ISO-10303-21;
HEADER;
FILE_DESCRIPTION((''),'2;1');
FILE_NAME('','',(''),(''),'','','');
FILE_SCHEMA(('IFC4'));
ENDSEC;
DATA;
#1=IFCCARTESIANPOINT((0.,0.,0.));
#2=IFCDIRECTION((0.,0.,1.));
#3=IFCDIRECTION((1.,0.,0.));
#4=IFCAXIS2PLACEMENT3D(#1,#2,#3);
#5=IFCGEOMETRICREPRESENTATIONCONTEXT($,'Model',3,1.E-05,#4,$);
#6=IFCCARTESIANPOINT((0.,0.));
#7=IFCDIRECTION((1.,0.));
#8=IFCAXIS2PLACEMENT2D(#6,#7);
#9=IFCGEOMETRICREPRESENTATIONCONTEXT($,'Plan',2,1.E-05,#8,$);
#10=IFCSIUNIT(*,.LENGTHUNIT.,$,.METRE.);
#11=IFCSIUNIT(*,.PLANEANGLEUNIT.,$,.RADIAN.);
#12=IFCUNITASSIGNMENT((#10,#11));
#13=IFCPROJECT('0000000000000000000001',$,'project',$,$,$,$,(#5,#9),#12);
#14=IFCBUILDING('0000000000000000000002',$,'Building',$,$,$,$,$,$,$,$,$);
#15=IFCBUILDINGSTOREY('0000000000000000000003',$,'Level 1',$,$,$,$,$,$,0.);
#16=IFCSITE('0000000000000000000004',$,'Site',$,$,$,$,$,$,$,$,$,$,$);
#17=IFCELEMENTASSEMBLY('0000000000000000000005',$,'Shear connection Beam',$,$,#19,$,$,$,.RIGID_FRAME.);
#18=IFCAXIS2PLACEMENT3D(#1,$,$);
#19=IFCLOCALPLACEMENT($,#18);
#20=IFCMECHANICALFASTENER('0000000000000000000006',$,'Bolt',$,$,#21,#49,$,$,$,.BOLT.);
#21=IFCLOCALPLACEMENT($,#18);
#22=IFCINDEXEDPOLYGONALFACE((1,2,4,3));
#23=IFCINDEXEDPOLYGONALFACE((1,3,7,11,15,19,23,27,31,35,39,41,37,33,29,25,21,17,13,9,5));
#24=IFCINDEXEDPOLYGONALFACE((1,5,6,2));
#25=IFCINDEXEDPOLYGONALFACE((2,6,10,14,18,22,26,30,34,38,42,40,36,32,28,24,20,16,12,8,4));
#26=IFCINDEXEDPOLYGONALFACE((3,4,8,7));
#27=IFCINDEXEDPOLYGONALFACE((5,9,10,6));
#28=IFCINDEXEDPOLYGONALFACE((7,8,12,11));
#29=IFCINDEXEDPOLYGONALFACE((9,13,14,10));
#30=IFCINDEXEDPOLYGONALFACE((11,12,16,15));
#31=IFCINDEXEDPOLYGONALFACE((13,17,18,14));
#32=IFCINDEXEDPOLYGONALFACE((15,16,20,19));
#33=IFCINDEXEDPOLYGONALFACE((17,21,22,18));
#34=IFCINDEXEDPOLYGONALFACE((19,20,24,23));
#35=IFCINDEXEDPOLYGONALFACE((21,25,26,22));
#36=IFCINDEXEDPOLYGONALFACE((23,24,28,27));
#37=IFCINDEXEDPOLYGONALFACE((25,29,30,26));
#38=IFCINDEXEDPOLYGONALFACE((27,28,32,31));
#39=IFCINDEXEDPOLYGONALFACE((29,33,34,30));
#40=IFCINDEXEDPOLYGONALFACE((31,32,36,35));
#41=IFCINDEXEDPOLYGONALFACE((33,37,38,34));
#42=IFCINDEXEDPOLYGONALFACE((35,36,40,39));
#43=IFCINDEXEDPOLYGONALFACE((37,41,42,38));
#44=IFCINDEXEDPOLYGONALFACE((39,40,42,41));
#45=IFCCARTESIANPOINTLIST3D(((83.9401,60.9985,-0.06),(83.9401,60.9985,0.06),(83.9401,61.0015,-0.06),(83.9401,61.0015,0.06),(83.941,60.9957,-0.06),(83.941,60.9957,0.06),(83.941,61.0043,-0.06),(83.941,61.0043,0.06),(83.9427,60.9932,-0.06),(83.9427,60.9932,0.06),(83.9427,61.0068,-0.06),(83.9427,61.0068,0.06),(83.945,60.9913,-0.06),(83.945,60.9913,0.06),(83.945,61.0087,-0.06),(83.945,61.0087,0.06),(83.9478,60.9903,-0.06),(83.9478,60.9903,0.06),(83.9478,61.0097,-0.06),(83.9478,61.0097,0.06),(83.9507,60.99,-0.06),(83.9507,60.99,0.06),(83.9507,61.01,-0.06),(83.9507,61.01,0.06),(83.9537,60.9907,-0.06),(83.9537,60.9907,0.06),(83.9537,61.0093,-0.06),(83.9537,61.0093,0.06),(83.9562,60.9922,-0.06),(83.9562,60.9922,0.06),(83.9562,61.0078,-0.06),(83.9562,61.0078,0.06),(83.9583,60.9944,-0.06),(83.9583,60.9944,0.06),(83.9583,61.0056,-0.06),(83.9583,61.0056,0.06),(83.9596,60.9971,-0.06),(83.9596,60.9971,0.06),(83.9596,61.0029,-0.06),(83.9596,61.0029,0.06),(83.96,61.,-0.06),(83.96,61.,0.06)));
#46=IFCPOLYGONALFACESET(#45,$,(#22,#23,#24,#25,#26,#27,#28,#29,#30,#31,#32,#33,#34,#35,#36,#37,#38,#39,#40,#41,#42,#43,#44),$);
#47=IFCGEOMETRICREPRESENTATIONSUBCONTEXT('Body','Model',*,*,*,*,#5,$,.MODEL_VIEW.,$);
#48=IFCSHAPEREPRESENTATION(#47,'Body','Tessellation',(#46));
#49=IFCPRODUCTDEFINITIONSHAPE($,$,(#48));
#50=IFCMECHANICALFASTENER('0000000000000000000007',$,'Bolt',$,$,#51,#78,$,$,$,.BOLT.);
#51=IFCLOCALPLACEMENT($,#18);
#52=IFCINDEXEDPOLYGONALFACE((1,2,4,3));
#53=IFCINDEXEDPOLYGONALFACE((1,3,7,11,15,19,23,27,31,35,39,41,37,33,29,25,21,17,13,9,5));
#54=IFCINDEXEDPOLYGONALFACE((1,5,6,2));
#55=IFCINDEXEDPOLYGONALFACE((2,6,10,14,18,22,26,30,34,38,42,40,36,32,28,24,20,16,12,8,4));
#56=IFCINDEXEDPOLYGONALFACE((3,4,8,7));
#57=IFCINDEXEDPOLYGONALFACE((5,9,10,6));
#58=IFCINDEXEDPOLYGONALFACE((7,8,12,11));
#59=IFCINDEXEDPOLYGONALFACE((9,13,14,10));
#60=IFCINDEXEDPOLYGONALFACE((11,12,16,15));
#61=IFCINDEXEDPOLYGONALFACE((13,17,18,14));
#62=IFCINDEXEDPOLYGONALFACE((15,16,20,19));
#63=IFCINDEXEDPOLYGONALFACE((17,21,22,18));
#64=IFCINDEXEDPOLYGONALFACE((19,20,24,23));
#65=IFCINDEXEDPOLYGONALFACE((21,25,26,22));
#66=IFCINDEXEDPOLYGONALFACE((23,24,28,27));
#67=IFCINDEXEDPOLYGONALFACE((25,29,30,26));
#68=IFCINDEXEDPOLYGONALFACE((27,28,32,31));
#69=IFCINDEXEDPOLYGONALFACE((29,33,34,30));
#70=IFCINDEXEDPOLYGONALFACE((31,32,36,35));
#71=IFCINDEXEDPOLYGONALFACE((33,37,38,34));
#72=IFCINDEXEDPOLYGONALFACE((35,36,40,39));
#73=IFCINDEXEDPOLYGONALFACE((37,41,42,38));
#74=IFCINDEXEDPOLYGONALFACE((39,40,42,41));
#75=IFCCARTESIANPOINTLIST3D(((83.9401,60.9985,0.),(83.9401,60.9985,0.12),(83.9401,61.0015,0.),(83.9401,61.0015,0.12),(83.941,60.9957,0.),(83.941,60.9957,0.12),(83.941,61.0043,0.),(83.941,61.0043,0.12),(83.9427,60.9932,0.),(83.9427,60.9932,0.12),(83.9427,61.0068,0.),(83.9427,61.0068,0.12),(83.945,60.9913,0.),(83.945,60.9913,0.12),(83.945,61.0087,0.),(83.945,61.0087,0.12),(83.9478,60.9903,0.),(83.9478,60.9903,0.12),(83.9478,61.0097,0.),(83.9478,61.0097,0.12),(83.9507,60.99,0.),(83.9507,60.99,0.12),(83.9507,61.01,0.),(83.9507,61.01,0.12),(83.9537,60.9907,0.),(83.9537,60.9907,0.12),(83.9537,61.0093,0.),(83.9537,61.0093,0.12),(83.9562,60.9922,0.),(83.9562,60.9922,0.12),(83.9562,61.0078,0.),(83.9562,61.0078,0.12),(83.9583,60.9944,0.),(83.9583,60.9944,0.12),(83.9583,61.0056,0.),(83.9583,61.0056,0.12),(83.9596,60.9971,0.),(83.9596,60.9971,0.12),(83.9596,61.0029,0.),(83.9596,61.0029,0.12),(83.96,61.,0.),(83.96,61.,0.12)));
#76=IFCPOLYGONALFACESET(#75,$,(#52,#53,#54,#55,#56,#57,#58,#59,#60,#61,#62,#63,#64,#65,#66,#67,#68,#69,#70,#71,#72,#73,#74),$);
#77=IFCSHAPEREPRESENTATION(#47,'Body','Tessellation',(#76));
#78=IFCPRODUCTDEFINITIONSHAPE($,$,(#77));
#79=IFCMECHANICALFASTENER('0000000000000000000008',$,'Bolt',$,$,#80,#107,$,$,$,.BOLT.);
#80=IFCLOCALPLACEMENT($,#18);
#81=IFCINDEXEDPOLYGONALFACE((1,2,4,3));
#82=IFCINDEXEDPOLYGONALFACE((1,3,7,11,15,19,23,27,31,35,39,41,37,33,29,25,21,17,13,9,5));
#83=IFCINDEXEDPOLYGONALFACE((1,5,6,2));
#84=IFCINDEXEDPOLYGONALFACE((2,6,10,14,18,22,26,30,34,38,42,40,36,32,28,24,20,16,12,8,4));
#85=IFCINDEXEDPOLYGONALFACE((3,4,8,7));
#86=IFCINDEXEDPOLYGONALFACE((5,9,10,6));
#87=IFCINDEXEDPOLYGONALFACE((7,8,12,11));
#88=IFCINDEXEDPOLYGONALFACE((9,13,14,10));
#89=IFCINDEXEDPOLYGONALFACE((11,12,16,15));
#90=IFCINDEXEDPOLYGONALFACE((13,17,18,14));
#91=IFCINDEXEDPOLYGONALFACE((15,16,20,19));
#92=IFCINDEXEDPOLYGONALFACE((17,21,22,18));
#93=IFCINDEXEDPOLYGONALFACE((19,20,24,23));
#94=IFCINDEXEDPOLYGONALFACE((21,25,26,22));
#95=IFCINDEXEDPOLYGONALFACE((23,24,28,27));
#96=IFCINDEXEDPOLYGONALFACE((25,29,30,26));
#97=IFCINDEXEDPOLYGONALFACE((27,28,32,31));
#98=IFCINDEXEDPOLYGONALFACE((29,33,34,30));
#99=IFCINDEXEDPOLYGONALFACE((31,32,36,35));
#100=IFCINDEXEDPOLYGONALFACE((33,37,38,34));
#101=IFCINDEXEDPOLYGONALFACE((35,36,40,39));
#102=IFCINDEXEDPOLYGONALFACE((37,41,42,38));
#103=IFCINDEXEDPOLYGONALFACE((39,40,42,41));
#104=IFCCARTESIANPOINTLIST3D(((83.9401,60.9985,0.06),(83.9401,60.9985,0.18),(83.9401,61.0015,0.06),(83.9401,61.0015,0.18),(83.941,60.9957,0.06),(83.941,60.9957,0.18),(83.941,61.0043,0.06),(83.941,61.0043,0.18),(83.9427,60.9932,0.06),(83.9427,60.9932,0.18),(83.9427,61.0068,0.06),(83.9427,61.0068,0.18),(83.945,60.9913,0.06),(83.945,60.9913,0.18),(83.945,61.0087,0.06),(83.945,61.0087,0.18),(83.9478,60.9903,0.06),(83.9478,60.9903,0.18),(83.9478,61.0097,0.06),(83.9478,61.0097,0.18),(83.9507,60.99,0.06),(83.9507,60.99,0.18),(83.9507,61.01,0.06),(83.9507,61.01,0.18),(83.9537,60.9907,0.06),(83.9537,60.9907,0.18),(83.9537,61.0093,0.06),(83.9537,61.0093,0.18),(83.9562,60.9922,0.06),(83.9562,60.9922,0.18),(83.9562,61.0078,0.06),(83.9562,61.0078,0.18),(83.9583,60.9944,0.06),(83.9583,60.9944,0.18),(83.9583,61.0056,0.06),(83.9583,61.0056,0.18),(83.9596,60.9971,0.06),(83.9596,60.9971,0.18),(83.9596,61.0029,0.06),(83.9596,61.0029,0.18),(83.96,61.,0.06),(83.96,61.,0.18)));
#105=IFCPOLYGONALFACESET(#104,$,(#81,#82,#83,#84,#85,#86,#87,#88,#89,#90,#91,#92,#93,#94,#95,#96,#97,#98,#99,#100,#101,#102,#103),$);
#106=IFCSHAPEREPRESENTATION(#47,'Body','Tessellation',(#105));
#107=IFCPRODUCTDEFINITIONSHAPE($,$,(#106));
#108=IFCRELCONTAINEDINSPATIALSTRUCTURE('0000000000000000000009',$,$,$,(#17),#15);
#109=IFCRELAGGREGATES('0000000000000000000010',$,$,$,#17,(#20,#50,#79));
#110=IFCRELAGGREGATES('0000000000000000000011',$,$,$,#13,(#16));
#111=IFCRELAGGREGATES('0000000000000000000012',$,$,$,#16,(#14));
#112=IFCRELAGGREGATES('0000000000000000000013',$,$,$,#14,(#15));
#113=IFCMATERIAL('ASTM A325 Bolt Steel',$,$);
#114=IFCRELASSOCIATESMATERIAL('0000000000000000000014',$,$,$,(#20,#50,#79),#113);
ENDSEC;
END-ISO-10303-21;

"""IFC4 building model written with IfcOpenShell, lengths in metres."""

from ifc_helpers import new_model, si_unit, frame, origin_with_axes, origin_2d, origin_2d_with_axis, place, context, subcontext, project, spatial, circle, extrude, material, element, aggregate, save


model = new_model("IFC4")

# Units and contexts
model_context = context("Model", 3, precision=1e-05, world=origin_with_axes())
plan_context = context("Plan", 2, precision=1e-05, world=origin_2d_with_axis())
body_context = subcontext(model_context, "Body", "Model", "MODEL_VIEW")
ifc_project = project(units=[si_unit("LENGTHUNIT", "METRE"), si_unit("PLANEANGLEUNIT", "RADIAN")], contexts=[model_context, plan_context])

# Site, building, storey
site = spatial("IfcSite", under=ifc_project, Name="Site")
building = spatial("IfcBuilding", under=site, Name="Building")
storey = spatial("IfcBuildingStorey", under=building, Name="Level 1", Elevation=0.0)

# Shared definitions
ifc_material_1 = material(Name="ASTM A325 Bolt Steel")

# Element assembly, mechanical fasteners
assembly_1 = element("IfcElementAssembly", 1, inside=storey, Name="Shear connection Beam", PredefinedType="RIGID_FRAME")
mechanical_fastener_1_placement = place(None, frame((83.95, 61.0, -0.06), z_axis=(0.0, 0.0, 1.0), x_axis=(1.0, 0.0, 0.0)))
mechanical_fastener_1 = element("IfcMechanicalFastener", 2, at=mechanical_fastener_1_placement, material=ifc_material_1, Name="Bolt", PredefinedType="BOLT", context=body_context, shape_type="SweptSolid", body=[
    extrude(circle(Radius=0.01, at=origin_2d()), origin_with_axes(), (0.0, 0.0, 1.0), 0.12),
])
mechanical_fastener_2_placement = place(None, frame((83.95, 61.0, 0.0), z_axis=(0.0, 0.0, 1.0), x_axis=(1.0, 0.0, 0.0)))
mechanical_fastener_2 = element("IfcMechanicalFastener", 3, at=mechanical_fastener_2_placement, material=ifc_material_1, Name="Bolt", PredefinedType="BOLT", context=body_context, shape_type="SweptSolid", body=[
    extrude(circle(Radius=0.01, at=origin_2d()), origin_with_axes(), (0.0, 0.0, 1.0), 0.12),
])
mechanical_fastener_3_placement = place(None, frame((83.95, 61.0, 0.06), z_axis=(0.0, 0.0, 1.0), x_axis=(1.0, 0.0, 0.0)))
mechanical_fastener_3 = element("IfcMechanicalFastener", 4, at=mechanical_fastener_3_placement, material=ifc_material_1, Name="Bolt", PredefinedType="BOLT", context=body_context, shape_type="SweptSolid", body=[
    extrude(circle(Radius=0.01, at=origin_2d()), origin_with_axes(), (0.0, 0.0, 1.0), 0.12),
])
aggregate(assembly_1, [mechanical_fastener_1, mechanical_fastener_2, mechanical_fastener_3])

save(model, "model.ifc")
